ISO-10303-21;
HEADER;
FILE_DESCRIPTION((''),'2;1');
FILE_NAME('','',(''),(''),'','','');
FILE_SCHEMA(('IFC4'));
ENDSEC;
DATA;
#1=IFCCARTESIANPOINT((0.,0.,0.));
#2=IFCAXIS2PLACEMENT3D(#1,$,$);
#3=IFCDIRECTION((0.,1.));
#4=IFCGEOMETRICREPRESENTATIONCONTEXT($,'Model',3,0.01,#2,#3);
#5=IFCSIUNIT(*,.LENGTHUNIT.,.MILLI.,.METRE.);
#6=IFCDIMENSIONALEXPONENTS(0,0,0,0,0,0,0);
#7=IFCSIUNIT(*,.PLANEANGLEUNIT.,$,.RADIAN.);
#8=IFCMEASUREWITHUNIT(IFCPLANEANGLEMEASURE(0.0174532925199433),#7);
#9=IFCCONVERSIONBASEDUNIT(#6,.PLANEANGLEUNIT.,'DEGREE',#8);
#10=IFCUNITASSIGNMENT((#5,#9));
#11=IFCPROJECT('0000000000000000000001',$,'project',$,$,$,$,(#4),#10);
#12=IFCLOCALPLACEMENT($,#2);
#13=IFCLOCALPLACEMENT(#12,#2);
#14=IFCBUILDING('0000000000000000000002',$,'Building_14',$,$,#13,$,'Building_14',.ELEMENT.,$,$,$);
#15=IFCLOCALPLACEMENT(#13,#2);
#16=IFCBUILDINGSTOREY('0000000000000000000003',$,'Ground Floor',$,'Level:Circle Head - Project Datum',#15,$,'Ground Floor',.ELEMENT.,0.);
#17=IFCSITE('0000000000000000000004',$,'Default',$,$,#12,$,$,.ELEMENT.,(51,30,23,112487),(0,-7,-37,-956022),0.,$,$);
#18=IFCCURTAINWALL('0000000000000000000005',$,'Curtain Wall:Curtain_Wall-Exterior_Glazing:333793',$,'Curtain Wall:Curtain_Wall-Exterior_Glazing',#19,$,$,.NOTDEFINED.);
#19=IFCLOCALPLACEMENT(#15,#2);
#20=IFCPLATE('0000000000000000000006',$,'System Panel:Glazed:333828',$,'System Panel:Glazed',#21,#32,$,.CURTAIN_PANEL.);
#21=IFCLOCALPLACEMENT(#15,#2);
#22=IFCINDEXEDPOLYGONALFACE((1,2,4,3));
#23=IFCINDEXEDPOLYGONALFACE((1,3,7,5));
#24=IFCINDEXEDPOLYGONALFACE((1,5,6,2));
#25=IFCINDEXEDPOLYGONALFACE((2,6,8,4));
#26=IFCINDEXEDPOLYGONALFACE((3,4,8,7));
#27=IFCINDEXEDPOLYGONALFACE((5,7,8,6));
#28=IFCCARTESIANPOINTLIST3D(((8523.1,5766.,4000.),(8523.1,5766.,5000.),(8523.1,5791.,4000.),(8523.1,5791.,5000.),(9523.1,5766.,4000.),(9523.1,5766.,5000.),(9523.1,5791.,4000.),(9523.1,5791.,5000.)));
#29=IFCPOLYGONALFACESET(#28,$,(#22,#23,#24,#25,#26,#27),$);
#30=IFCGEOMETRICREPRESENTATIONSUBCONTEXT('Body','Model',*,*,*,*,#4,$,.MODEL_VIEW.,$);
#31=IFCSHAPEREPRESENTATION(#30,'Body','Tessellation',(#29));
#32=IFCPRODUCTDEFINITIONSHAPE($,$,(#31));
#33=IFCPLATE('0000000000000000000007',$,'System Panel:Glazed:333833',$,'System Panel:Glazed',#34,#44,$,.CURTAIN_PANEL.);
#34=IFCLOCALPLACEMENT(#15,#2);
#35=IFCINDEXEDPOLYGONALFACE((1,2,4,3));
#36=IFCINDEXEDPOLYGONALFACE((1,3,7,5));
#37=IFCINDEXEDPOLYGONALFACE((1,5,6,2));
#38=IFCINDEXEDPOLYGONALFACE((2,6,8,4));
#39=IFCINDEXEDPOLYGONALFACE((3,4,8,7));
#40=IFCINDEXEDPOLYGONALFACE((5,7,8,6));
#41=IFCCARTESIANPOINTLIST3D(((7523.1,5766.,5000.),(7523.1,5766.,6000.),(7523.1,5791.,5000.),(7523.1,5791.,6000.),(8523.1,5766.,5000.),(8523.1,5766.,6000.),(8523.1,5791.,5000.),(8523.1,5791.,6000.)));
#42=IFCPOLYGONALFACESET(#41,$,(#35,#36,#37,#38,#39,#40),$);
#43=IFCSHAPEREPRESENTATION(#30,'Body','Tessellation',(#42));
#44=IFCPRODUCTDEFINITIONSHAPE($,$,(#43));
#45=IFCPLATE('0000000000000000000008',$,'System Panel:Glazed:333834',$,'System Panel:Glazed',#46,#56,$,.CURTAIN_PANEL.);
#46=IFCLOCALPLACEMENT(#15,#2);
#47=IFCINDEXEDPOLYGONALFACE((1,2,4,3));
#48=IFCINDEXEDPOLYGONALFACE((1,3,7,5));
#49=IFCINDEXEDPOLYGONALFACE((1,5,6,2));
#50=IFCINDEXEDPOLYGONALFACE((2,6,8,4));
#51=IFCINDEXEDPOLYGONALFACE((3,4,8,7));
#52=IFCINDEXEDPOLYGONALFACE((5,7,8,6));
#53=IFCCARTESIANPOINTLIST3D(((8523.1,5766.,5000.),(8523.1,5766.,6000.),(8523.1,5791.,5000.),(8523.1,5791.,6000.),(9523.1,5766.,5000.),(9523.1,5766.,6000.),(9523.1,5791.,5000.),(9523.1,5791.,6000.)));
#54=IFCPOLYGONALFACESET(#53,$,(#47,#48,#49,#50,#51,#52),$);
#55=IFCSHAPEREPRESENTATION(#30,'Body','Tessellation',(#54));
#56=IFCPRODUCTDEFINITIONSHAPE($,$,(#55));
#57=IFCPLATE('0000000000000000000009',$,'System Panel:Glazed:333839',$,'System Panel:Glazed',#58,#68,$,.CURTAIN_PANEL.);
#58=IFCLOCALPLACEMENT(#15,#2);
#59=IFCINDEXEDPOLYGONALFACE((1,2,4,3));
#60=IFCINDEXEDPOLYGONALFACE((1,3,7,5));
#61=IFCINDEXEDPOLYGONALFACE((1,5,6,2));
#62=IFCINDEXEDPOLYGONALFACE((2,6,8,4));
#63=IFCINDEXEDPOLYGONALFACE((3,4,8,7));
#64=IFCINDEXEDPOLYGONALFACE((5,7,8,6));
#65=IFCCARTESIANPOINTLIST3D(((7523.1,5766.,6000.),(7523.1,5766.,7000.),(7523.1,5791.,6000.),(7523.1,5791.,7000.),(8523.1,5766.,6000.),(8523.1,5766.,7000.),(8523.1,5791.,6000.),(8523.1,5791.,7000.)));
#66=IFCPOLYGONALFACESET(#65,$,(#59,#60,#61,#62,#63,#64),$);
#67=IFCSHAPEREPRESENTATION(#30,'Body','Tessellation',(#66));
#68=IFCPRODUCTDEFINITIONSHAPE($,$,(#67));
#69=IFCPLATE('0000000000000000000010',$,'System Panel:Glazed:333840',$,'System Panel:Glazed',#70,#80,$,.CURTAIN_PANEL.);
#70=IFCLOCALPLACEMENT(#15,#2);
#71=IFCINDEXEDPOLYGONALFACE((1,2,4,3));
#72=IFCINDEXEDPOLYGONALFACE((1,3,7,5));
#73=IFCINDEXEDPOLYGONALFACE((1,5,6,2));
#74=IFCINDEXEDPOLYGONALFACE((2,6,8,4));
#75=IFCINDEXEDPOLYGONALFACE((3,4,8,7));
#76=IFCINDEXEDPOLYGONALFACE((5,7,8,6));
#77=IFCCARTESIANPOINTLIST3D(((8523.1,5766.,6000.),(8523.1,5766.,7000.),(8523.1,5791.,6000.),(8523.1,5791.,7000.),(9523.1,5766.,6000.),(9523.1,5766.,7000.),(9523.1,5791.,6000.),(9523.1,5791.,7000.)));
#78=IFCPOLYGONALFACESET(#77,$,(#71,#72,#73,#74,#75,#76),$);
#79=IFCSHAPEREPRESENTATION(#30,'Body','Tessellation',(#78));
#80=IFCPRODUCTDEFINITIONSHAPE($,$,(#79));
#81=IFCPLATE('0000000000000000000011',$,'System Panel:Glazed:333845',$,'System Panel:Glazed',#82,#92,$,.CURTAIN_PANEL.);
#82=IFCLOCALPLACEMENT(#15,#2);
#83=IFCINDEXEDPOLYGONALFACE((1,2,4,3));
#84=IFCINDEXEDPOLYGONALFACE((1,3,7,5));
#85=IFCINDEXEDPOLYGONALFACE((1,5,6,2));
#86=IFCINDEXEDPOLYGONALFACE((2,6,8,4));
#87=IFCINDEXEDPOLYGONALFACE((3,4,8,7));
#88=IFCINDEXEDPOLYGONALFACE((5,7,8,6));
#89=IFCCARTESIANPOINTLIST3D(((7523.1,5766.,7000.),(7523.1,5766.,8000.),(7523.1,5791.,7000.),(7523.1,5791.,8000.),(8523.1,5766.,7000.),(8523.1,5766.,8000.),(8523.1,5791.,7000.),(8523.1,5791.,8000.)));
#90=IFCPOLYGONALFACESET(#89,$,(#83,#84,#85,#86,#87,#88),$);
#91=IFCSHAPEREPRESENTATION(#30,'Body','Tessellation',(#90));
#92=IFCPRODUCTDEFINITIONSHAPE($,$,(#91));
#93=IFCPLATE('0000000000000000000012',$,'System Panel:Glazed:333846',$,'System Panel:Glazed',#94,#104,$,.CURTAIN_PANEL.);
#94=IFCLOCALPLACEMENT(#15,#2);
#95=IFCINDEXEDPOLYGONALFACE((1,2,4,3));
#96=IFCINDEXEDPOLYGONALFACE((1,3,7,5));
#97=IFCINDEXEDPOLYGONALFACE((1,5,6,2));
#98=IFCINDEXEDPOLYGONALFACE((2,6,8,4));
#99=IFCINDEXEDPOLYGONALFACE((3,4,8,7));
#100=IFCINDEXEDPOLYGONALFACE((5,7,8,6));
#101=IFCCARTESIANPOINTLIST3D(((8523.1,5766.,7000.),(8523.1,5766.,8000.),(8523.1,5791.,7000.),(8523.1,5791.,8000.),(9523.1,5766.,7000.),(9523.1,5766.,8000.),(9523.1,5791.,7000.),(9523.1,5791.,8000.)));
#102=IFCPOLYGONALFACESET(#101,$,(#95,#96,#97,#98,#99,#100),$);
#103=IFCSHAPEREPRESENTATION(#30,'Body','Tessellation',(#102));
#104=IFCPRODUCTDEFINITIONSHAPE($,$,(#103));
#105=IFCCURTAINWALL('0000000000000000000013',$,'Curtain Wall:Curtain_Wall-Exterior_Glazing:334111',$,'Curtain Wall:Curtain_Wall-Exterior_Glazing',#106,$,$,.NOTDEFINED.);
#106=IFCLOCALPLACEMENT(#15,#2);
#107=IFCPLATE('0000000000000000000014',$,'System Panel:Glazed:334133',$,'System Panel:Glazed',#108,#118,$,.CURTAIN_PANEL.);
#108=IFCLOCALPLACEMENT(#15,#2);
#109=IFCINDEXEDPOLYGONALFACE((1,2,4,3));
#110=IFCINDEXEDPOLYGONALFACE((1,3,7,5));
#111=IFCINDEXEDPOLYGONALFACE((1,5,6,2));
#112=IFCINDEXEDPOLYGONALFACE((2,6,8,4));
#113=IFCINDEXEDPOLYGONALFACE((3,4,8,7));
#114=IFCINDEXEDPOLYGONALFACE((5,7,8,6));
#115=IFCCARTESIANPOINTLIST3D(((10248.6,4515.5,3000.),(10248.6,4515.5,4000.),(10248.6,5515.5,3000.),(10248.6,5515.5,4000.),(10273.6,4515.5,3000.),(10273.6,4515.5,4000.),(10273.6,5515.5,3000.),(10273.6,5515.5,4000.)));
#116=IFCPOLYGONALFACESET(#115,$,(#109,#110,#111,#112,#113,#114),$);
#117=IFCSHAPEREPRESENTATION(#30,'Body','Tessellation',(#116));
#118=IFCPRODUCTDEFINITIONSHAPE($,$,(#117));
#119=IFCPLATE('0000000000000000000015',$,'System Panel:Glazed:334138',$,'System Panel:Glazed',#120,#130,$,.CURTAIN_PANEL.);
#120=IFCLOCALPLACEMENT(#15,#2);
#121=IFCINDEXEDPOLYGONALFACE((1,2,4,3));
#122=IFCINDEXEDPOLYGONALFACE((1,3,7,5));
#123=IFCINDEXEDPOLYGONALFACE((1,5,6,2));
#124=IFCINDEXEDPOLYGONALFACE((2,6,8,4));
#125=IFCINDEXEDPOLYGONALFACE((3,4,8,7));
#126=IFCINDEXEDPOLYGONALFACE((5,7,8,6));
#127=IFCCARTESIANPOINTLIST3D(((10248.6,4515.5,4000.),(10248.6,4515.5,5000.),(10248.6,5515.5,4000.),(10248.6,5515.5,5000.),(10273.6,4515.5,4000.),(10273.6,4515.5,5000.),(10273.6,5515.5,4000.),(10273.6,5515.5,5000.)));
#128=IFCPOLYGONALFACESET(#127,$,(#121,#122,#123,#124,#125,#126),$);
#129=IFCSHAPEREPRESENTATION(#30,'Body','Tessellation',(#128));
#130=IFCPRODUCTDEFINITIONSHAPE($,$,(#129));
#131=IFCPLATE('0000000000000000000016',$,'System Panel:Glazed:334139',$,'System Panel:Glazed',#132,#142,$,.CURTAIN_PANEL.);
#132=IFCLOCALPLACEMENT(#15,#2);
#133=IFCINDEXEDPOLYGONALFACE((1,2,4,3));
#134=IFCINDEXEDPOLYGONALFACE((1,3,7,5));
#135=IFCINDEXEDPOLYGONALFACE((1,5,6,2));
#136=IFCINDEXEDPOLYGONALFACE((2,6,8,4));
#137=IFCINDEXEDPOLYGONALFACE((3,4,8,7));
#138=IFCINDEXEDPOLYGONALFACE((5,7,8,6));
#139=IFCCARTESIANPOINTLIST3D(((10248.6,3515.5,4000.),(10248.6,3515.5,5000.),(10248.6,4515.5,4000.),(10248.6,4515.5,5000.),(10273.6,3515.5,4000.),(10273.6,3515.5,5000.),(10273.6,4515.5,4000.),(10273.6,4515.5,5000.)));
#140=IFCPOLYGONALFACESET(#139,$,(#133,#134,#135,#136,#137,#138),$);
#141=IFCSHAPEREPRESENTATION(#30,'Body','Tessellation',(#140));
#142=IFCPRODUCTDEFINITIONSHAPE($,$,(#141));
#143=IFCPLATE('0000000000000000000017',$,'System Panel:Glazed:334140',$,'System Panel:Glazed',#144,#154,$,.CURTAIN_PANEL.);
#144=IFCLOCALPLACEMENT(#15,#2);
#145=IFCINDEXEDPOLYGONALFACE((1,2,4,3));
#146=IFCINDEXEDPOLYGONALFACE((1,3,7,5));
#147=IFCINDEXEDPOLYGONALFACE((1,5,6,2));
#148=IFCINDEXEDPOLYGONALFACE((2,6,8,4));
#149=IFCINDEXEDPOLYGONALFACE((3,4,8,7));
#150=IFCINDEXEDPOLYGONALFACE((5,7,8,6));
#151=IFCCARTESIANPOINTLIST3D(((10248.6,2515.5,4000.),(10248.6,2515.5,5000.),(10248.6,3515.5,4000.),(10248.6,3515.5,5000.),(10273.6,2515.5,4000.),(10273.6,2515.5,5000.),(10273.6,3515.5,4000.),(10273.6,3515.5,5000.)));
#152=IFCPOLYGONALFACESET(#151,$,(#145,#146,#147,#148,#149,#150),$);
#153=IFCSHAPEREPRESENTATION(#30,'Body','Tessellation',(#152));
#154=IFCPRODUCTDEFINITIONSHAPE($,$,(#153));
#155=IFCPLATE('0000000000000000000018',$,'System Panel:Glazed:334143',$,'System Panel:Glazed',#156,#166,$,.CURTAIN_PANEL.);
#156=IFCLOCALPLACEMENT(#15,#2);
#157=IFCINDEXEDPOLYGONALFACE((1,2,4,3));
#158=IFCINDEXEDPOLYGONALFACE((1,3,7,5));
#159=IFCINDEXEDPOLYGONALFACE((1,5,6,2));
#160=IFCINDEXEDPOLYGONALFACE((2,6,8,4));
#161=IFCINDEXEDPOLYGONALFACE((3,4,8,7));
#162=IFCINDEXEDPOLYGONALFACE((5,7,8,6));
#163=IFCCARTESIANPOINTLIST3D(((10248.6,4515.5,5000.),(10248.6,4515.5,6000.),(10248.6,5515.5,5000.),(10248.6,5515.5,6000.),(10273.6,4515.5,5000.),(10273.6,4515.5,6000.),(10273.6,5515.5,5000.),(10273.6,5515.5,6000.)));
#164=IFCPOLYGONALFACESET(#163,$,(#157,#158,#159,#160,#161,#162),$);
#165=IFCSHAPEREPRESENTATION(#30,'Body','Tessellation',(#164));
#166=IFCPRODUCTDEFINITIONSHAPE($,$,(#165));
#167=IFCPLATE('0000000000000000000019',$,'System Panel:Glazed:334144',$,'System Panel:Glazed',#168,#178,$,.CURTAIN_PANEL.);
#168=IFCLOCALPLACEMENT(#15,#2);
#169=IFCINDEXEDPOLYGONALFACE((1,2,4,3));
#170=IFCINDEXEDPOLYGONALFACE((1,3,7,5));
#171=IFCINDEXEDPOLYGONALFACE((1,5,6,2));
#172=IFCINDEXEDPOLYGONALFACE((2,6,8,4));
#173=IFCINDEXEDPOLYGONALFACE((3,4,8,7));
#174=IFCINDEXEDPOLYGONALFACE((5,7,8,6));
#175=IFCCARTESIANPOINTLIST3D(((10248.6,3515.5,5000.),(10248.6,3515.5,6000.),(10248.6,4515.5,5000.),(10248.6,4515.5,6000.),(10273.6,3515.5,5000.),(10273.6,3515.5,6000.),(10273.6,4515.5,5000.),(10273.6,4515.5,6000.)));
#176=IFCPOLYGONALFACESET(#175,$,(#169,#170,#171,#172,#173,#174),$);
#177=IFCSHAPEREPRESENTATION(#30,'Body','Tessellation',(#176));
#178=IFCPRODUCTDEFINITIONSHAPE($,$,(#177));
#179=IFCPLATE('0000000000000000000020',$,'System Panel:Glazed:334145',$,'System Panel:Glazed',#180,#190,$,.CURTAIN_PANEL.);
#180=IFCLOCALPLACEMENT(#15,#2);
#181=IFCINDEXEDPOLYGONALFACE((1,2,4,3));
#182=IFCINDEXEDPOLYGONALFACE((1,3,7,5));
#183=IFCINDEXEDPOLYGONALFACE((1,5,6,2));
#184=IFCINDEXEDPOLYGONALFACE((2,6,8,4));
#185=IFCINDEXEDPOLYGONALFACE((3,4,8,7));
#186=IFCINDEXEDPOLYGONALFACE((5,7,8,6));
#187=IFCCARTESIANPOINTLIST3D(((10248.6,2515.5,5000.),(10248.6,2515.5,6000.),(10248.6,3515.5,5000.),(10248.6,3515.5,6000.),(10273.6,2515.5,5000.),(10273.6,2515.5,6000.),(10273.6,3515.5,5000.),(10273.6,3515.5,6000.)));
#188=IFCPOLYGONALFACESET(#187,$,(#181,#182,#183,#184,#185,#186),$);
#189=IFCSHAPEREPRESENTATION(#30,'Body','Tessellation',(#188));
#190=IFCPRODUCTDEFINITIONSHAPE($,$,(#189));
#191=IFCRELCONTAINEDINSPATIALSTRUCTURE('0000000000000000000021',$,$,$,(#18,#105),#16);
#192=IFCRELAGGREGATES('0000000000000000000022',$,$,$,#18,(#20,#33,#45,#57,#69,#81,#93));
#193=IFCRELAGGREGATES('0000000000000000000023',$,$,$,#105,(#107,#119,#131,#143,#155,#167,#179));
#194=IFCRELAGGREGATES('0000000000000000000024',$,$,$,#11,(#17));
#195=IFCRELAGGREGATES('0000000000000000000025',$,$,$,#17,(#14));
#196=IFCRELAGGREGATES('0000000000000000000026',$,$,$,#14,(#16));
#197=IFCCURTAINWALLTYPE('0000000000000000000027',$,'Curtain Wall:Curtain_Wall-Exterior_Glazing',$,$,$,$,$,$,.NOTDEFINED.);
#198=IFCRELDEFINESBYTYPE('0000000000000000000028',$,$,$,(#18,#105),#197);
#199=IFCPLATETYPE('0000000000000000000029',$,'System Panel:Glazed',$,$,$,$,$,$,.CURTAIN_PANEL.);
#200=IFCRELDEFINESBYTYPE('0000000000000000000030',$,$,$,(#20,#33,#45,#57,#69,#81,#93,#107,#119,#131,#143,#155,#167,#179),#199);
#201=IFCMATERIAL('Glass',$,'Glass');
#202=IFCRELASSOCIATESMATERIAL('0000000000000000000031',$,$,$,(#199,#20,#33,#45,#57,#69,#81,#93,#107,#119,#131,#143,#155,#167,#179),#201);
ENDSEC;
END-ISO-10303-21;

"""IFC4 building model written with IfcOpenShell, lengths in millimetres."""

from ifc_helpers import new_model, entity, si_unit, converted_unit, direction, frame, origin, place, context, subcontext, project, spatial, indexed_curve, outline, extrude, source, transform, mapped, material, type_object, type_shapes, element, aggregate, save


model = new_model("IFC4")

# Units and contexts
model_context = context("Model", 3, precision=0.01, world=origin(), true_north=direction((0.0, 1.0)))
body_context = subcontext(model_context, "Body", "Model", "MODEL_VIEW")
ifc_project = project(units=[si_unit("LENGTHUNIT", "METRE", prefix="MILLI"), converted_unit("PLANEANGLEUNIT", "DEGREE", entity("IfcPlaneAngleMeasure", 0.0174532925199433), si_unit("PLANEANGLEUNIT", "RADIAN"), dimensions=[0, 0, 0, 0, 0, 0, 0])], contexts=[model_context])

# Site, building, storey
site_placement = place(None, origin())
site = spatial("IfcSite", under=ifc_project, at=site_placement, Name="Default", CompositionType="ELEMENT", RefLatitude=(51, 30, 23, 112487), RefLongitude=(0, -7, -37, -956022), RefElevation=0.0)
building_placement = place(site_placement, origin())
building = spatial("IfcBuilding", under=site, at=building_placement, Name="Building_14", LongName="Building_14", CompositionType="ELEMENT")
storey_placement = place(building_placement, origin())
storey = spatial("IfcBuildingStorey", under=building, at=storey_placement, Name="Ground Floor", ObjectType="Level:Circle Head - Project Datum", LongName="Ground Floor", CompositionType="ELEMENT", Elevation=0.0)

# Curtain walls, plates
curtain_wall_type = type_object("IfcCurtainWallType", Name="Curtain Wall:Curtain_Wall-Exterior_Glazing", PredefinedType="NOTDEFINED")
curtain_wall_1_placement = place(storey_placement, origin())
curtain_wall_1 = element("IfcCurtainWall", 1, at=curtain_wall_1_placement, inside=storey, type_object=curtain_wall_type, Name="Curtain Wall:Curtain_Wall-Exterior_Glazing:333793", ObjectType="Curtain Wall:Curtain_Wall-Exterior_Glazing", PredefinedType="NOTDEFINED")
ifc_material = material(Name="Glass", Category="Glass")
plate_type_1 = type_object("IfcPlateType", Name="System Panel:Glazed", PredefinedType="CURTAIN_PANEL", material=ifc_material)
shared_shape_1 = source(origin(), body_context, "Body", "SweptSolid", [
    extrude(outline(indexed_curve([(-12.5, -500.0), (12.5, -500.0), (12.5, 500.0), (-12.5, 500.0), (-12.5, -500.0)], self_intersect=False)), frame((0.0, -37.0, 0.0), z_axis=(0.0, 0.0, 1.0), x_axis=(0.0, 1.0, 0.0)), (0.0, 0.0, 1.0), 1000.0),
])
type_shapes(plate_type_1, [shared_shape_1])
plate_1_placement = place(curtain_wall_1_placement, frame((9023.1, 5815.5, 4000.0)))
plate_1 = element("IfcPlate", 2, at=plate_1_placement, type_object=plate_type_1, material=ifc_material, Name="System Panel:Glazed:333828", ObjectType="System Panel:Glazed", PredefinedType="CURTAIN_PANEL", context=body_context, shape_type="MappedRepresentation", body=[
    mapped(shared_shape_1, transform((0.0, 0.0, 0.0), scale=1.0)),
])
plate_2_placement = place(curtain_wall_1_placement, frame((8023.1, 5815.5, 5000.0)))
plate_2 = element("IfcPlate", 3, at=plate_2_placement, type_object=plate_type_1, material=ifc_material, Name="System Panel:Glazed:333833", ObjectType="System Panel:Glazed", PredefinedType="CURTAIN_PANEL", context=body_context, shape_type="MappedRepresentation", body=[
    mapped(shared_shape_1, transform((0.0, 0.0, 0.0), scale=1.0)),
])
plate_3_placement = place(curtain_wall_1_placement, frame((9023.1, 5815.5, 5000.0)))
plate_3 = element("IfcPlate", 4, at=plate_3_placement, type_object=plate_type_1, material=ifc_material, Name="System Panel:Glazed:333834", ObjectType="System Panel:Glazed", PredefinedType="CURTAIN_PANEL", context=body_context, shape_type="MappedRepresentation", body=[
    mapped(shared_shape_1, transform((0.0, 0.0, 0.0), scale=1.0)),
])
plate_4_placement = place(curtain_wall_1_placement, frame((8023.1, 5815.5, 6000.0)))
plate_4 = element("IfcPlate", 5, at=plate_4_placement, type_object=plate_type_1, material=ifc_material, Name="System Panel:Glazed:333839", ObjectType="System Panel:Glazed", PredefinedType="CURTAIN_PANEL", context=body_context, shape_type="MappedRepresentation", body=[
    mapped(shared_shape_1, transform((0.0, 0.0, 0.0), scale=1.0)),
])
plate_5_placement = place(curtain_wall_1_placement, frame((9023.1, 5815.5, 6000.0)))
plate_5 = element("IfcPlate", 6, at=plate_5_placement, type_object=plate_type_1, material=ifc_material, Name="System Panel:Glazed:333840", ObjectType="System Panel:Glazed", PredefinedType="CURTAIN_PANEL", context=body_context, shape_type="MappedRepresentation", body=[
    mapped(shared_shape_1, transform((0.0, 0.0, 0.0), scale=1.0)),
])
plate_6_placement = place(curtain_wall_1_placement, frame((8023.1, 5815.5, 7000.0)))
plate_6 = element("IfcPlate", 7, at=plate_6_placement, type_object=plate_type_1, material=ifc_material, Name="System Panel:Glazed:333845", ObjectType="System Panel:Glazed", PredefinedType="CURTAIN_PANEL", context=body_context, shape_type="MappedRepresentation", body=[
    mapped(shared_shape_1, transform((0.0, 0.0, 0.0), scale=1.0)),
])
plate_7_placement = place(curtain_wall_1_placement, frame((9023.1, 5815.5, 7000.0)))
plate_7 = element("IfcPlate", 8, at=plate_7_placement, type_object=plate_type_1, material=ifc_material, Name="System Panel:Glazed:333846", ObjectType="System Panel:Glazed", PredefinedType="CURTAIN_PANEL", context=body_context, shape_type="MappedRepresentation", body=[
    mapped(shared_shape_1, transform((0.0, 0.0, 0.0), scale=1.0)),
])
curtain_wall_2_placement = place(storey_placement, origin())
curtain_wall_2 = element("IfcCurtainWall", 9, at=curtain_wall_2_placement, inside=storey, type_object=curtain_wall_type, Name="Curtain Wall:Curtain_Wall-Exterior_Glazing:334111", ObjectType="Curtain Wall:Curtain_Wall-Exterior_Glazing", PredefinedType="NOTDEFINED")
plate_8_placement = place(curtain_wall_2_placement, frame((10298.1, 5015.5, 3000.0), z_axis=(0.0, 0.0, 1.0), x_axis=(0.0, -1.0, 0.0)))
plate_8 = element("IfcPlate", 10, at=plate_8_placement, type_object=plate_type_1, material=ifc_material, Name="System Panel:Glazed:334133", ObjectType="System Panel:Glazed", PredefinedType="CURTAIN_PANEL", context=body_context, shape_type="MappedRepresentation", body=[
    mapped(shared_shape_1, transform((0.0, 0.0, 0.0), scale=1.0)),
])
plate_9_placement = place(curtain_wall_2_placement, frame((10298.1, 5015.5, 4000.0), z_axis=(0.0, 0.0, 1.0), x_axis=(0.0, -1.0, 0.0)))
plate_9 = element("IfcPlate", 11, at=plate_9_placement, type_object=plate_type_1, material=ifc_material, Name="System Panel:Glazed:334138", ObjectType="System Panel:Glazed", PredefinedType="CURTAIN_PANEL", context=body_context, shape_type="MappedRepresentation", body=[
    mapped(shared_shape_1, transform((0.0, 0.0, 0.0), scale=1.0)),
])
plate_10_placement = place(curtain_wall_2_placement, frame((10298.1, 4015.5, 4000.0), z_axis=(0.0, 0.0, 1.0), x_axis=(0.0, -1.0, 0.0)))
plate_10 = element("IfcPlate", 12, at=plate_10_placement, type_object=plate_type_1, material=ifc_material, Name="System Panel:Glazed:334139", ObjectType="System Panel:Glazed", PredefinedType="CURTAIN_PANEL", context=body_context, shape_type="MappedRepresentation", body=[
    mapped(shared_shape_1, transform((0.0, 0.0, 0.0), scale=1.0)),
])
plate_11_placement = place(curtain_wall_2_placement, frame((10298.1, 3015.5, 4000.0), z_axis=(0.0, 0.0, 1.0), x_axis=(0.0, -1.0, 0.0)))
plate_11 = element("IfcPlate", 13, at=plate_11_placement, type_object=plate_type_1, material=ifc_material, Name="System Panel:Glazed:334140", ObjectType="System Panel:Glazed", PredefinedType="CURTAIN_PANEL", context=body_context, shape_type="MappedRepresentation", body=[
    mapped(shared_shape_1, transform((0.0, 0.0, 0.0), scale=1.0)),
])
plate_12_placement = place(curtain_wall_2_placement, frame((10298.1, 5015.5, 5000.0), z_axis=(0.0, 0.0, 1.0), x_axis=(0.0, -1.0, 0.0)))
plate_12 = element("IfcPlate", 14, at=plate_12_placement, type_object=plate_type_1, material=ifc_material, Name="System Panel:Glazed:334143", ObjectType="System Panel:Glazed", PredefinedType="CURTAIN_PANEL", context=body_context, shape_type="MappedRepresentation", body=[
    mapped(shared_shape_1, transform((0.0, 0.0, 0.0), scale=1.0)),
])
plate_13_placement = place(curtain_wall_2_placement, frame((10298.1, 4015.5, 5000.0), z_axis=(0.0, 0.0, 1.0), x_axis=(0.0, -1.0, 0.0)))
plate_13 = element("IfcPlate", 15, at=plate_13_placement, type_object=plate_type_1, material=ifc_material, Name="System Panel:Glazed:334144", ObjectType="System Panel:Glazed", PredefinedType="CURTAIN_PANEL", context=body_context, shape_type="MappedRepresentation", body=[
    mapped(shared_shape_1, transform((0.0, 0.0, 0.0), scale=1.0)),
])
plate_14_placement = place(curtain_wall_2_placement, frame((10298.1, 3015.5, 5000.0), z_axis=(0.0, 0.0, 1.0), x_axis=(0.0, -1.0, 0.0)))
plate_14 = element("IfcPlate", 16, at=plate_14_placement, type_object=plate_type_1, material=ifc_material, Name="System Panel:Glazed:334145", ObjectType="System Panel:Glazed", PredefinedType="CURTAIN_PANEL", context=body_context, shape_type="MappedRepresentation", body=[
    mapped(shared_shape_1, transform((0.0, 0.0, 0.0), scale=1.0)),
])

aggregate(curtain_wall_1, [plate_1, plate_2, plate_3, plate_4, plate_5, plate_6, plate_7])
aggregate(curtain_wall_2, [plate_8, plate_9, plate_10, plate_11, plate_12, plate_13, plate_14])

save(model, "model.ifc")
